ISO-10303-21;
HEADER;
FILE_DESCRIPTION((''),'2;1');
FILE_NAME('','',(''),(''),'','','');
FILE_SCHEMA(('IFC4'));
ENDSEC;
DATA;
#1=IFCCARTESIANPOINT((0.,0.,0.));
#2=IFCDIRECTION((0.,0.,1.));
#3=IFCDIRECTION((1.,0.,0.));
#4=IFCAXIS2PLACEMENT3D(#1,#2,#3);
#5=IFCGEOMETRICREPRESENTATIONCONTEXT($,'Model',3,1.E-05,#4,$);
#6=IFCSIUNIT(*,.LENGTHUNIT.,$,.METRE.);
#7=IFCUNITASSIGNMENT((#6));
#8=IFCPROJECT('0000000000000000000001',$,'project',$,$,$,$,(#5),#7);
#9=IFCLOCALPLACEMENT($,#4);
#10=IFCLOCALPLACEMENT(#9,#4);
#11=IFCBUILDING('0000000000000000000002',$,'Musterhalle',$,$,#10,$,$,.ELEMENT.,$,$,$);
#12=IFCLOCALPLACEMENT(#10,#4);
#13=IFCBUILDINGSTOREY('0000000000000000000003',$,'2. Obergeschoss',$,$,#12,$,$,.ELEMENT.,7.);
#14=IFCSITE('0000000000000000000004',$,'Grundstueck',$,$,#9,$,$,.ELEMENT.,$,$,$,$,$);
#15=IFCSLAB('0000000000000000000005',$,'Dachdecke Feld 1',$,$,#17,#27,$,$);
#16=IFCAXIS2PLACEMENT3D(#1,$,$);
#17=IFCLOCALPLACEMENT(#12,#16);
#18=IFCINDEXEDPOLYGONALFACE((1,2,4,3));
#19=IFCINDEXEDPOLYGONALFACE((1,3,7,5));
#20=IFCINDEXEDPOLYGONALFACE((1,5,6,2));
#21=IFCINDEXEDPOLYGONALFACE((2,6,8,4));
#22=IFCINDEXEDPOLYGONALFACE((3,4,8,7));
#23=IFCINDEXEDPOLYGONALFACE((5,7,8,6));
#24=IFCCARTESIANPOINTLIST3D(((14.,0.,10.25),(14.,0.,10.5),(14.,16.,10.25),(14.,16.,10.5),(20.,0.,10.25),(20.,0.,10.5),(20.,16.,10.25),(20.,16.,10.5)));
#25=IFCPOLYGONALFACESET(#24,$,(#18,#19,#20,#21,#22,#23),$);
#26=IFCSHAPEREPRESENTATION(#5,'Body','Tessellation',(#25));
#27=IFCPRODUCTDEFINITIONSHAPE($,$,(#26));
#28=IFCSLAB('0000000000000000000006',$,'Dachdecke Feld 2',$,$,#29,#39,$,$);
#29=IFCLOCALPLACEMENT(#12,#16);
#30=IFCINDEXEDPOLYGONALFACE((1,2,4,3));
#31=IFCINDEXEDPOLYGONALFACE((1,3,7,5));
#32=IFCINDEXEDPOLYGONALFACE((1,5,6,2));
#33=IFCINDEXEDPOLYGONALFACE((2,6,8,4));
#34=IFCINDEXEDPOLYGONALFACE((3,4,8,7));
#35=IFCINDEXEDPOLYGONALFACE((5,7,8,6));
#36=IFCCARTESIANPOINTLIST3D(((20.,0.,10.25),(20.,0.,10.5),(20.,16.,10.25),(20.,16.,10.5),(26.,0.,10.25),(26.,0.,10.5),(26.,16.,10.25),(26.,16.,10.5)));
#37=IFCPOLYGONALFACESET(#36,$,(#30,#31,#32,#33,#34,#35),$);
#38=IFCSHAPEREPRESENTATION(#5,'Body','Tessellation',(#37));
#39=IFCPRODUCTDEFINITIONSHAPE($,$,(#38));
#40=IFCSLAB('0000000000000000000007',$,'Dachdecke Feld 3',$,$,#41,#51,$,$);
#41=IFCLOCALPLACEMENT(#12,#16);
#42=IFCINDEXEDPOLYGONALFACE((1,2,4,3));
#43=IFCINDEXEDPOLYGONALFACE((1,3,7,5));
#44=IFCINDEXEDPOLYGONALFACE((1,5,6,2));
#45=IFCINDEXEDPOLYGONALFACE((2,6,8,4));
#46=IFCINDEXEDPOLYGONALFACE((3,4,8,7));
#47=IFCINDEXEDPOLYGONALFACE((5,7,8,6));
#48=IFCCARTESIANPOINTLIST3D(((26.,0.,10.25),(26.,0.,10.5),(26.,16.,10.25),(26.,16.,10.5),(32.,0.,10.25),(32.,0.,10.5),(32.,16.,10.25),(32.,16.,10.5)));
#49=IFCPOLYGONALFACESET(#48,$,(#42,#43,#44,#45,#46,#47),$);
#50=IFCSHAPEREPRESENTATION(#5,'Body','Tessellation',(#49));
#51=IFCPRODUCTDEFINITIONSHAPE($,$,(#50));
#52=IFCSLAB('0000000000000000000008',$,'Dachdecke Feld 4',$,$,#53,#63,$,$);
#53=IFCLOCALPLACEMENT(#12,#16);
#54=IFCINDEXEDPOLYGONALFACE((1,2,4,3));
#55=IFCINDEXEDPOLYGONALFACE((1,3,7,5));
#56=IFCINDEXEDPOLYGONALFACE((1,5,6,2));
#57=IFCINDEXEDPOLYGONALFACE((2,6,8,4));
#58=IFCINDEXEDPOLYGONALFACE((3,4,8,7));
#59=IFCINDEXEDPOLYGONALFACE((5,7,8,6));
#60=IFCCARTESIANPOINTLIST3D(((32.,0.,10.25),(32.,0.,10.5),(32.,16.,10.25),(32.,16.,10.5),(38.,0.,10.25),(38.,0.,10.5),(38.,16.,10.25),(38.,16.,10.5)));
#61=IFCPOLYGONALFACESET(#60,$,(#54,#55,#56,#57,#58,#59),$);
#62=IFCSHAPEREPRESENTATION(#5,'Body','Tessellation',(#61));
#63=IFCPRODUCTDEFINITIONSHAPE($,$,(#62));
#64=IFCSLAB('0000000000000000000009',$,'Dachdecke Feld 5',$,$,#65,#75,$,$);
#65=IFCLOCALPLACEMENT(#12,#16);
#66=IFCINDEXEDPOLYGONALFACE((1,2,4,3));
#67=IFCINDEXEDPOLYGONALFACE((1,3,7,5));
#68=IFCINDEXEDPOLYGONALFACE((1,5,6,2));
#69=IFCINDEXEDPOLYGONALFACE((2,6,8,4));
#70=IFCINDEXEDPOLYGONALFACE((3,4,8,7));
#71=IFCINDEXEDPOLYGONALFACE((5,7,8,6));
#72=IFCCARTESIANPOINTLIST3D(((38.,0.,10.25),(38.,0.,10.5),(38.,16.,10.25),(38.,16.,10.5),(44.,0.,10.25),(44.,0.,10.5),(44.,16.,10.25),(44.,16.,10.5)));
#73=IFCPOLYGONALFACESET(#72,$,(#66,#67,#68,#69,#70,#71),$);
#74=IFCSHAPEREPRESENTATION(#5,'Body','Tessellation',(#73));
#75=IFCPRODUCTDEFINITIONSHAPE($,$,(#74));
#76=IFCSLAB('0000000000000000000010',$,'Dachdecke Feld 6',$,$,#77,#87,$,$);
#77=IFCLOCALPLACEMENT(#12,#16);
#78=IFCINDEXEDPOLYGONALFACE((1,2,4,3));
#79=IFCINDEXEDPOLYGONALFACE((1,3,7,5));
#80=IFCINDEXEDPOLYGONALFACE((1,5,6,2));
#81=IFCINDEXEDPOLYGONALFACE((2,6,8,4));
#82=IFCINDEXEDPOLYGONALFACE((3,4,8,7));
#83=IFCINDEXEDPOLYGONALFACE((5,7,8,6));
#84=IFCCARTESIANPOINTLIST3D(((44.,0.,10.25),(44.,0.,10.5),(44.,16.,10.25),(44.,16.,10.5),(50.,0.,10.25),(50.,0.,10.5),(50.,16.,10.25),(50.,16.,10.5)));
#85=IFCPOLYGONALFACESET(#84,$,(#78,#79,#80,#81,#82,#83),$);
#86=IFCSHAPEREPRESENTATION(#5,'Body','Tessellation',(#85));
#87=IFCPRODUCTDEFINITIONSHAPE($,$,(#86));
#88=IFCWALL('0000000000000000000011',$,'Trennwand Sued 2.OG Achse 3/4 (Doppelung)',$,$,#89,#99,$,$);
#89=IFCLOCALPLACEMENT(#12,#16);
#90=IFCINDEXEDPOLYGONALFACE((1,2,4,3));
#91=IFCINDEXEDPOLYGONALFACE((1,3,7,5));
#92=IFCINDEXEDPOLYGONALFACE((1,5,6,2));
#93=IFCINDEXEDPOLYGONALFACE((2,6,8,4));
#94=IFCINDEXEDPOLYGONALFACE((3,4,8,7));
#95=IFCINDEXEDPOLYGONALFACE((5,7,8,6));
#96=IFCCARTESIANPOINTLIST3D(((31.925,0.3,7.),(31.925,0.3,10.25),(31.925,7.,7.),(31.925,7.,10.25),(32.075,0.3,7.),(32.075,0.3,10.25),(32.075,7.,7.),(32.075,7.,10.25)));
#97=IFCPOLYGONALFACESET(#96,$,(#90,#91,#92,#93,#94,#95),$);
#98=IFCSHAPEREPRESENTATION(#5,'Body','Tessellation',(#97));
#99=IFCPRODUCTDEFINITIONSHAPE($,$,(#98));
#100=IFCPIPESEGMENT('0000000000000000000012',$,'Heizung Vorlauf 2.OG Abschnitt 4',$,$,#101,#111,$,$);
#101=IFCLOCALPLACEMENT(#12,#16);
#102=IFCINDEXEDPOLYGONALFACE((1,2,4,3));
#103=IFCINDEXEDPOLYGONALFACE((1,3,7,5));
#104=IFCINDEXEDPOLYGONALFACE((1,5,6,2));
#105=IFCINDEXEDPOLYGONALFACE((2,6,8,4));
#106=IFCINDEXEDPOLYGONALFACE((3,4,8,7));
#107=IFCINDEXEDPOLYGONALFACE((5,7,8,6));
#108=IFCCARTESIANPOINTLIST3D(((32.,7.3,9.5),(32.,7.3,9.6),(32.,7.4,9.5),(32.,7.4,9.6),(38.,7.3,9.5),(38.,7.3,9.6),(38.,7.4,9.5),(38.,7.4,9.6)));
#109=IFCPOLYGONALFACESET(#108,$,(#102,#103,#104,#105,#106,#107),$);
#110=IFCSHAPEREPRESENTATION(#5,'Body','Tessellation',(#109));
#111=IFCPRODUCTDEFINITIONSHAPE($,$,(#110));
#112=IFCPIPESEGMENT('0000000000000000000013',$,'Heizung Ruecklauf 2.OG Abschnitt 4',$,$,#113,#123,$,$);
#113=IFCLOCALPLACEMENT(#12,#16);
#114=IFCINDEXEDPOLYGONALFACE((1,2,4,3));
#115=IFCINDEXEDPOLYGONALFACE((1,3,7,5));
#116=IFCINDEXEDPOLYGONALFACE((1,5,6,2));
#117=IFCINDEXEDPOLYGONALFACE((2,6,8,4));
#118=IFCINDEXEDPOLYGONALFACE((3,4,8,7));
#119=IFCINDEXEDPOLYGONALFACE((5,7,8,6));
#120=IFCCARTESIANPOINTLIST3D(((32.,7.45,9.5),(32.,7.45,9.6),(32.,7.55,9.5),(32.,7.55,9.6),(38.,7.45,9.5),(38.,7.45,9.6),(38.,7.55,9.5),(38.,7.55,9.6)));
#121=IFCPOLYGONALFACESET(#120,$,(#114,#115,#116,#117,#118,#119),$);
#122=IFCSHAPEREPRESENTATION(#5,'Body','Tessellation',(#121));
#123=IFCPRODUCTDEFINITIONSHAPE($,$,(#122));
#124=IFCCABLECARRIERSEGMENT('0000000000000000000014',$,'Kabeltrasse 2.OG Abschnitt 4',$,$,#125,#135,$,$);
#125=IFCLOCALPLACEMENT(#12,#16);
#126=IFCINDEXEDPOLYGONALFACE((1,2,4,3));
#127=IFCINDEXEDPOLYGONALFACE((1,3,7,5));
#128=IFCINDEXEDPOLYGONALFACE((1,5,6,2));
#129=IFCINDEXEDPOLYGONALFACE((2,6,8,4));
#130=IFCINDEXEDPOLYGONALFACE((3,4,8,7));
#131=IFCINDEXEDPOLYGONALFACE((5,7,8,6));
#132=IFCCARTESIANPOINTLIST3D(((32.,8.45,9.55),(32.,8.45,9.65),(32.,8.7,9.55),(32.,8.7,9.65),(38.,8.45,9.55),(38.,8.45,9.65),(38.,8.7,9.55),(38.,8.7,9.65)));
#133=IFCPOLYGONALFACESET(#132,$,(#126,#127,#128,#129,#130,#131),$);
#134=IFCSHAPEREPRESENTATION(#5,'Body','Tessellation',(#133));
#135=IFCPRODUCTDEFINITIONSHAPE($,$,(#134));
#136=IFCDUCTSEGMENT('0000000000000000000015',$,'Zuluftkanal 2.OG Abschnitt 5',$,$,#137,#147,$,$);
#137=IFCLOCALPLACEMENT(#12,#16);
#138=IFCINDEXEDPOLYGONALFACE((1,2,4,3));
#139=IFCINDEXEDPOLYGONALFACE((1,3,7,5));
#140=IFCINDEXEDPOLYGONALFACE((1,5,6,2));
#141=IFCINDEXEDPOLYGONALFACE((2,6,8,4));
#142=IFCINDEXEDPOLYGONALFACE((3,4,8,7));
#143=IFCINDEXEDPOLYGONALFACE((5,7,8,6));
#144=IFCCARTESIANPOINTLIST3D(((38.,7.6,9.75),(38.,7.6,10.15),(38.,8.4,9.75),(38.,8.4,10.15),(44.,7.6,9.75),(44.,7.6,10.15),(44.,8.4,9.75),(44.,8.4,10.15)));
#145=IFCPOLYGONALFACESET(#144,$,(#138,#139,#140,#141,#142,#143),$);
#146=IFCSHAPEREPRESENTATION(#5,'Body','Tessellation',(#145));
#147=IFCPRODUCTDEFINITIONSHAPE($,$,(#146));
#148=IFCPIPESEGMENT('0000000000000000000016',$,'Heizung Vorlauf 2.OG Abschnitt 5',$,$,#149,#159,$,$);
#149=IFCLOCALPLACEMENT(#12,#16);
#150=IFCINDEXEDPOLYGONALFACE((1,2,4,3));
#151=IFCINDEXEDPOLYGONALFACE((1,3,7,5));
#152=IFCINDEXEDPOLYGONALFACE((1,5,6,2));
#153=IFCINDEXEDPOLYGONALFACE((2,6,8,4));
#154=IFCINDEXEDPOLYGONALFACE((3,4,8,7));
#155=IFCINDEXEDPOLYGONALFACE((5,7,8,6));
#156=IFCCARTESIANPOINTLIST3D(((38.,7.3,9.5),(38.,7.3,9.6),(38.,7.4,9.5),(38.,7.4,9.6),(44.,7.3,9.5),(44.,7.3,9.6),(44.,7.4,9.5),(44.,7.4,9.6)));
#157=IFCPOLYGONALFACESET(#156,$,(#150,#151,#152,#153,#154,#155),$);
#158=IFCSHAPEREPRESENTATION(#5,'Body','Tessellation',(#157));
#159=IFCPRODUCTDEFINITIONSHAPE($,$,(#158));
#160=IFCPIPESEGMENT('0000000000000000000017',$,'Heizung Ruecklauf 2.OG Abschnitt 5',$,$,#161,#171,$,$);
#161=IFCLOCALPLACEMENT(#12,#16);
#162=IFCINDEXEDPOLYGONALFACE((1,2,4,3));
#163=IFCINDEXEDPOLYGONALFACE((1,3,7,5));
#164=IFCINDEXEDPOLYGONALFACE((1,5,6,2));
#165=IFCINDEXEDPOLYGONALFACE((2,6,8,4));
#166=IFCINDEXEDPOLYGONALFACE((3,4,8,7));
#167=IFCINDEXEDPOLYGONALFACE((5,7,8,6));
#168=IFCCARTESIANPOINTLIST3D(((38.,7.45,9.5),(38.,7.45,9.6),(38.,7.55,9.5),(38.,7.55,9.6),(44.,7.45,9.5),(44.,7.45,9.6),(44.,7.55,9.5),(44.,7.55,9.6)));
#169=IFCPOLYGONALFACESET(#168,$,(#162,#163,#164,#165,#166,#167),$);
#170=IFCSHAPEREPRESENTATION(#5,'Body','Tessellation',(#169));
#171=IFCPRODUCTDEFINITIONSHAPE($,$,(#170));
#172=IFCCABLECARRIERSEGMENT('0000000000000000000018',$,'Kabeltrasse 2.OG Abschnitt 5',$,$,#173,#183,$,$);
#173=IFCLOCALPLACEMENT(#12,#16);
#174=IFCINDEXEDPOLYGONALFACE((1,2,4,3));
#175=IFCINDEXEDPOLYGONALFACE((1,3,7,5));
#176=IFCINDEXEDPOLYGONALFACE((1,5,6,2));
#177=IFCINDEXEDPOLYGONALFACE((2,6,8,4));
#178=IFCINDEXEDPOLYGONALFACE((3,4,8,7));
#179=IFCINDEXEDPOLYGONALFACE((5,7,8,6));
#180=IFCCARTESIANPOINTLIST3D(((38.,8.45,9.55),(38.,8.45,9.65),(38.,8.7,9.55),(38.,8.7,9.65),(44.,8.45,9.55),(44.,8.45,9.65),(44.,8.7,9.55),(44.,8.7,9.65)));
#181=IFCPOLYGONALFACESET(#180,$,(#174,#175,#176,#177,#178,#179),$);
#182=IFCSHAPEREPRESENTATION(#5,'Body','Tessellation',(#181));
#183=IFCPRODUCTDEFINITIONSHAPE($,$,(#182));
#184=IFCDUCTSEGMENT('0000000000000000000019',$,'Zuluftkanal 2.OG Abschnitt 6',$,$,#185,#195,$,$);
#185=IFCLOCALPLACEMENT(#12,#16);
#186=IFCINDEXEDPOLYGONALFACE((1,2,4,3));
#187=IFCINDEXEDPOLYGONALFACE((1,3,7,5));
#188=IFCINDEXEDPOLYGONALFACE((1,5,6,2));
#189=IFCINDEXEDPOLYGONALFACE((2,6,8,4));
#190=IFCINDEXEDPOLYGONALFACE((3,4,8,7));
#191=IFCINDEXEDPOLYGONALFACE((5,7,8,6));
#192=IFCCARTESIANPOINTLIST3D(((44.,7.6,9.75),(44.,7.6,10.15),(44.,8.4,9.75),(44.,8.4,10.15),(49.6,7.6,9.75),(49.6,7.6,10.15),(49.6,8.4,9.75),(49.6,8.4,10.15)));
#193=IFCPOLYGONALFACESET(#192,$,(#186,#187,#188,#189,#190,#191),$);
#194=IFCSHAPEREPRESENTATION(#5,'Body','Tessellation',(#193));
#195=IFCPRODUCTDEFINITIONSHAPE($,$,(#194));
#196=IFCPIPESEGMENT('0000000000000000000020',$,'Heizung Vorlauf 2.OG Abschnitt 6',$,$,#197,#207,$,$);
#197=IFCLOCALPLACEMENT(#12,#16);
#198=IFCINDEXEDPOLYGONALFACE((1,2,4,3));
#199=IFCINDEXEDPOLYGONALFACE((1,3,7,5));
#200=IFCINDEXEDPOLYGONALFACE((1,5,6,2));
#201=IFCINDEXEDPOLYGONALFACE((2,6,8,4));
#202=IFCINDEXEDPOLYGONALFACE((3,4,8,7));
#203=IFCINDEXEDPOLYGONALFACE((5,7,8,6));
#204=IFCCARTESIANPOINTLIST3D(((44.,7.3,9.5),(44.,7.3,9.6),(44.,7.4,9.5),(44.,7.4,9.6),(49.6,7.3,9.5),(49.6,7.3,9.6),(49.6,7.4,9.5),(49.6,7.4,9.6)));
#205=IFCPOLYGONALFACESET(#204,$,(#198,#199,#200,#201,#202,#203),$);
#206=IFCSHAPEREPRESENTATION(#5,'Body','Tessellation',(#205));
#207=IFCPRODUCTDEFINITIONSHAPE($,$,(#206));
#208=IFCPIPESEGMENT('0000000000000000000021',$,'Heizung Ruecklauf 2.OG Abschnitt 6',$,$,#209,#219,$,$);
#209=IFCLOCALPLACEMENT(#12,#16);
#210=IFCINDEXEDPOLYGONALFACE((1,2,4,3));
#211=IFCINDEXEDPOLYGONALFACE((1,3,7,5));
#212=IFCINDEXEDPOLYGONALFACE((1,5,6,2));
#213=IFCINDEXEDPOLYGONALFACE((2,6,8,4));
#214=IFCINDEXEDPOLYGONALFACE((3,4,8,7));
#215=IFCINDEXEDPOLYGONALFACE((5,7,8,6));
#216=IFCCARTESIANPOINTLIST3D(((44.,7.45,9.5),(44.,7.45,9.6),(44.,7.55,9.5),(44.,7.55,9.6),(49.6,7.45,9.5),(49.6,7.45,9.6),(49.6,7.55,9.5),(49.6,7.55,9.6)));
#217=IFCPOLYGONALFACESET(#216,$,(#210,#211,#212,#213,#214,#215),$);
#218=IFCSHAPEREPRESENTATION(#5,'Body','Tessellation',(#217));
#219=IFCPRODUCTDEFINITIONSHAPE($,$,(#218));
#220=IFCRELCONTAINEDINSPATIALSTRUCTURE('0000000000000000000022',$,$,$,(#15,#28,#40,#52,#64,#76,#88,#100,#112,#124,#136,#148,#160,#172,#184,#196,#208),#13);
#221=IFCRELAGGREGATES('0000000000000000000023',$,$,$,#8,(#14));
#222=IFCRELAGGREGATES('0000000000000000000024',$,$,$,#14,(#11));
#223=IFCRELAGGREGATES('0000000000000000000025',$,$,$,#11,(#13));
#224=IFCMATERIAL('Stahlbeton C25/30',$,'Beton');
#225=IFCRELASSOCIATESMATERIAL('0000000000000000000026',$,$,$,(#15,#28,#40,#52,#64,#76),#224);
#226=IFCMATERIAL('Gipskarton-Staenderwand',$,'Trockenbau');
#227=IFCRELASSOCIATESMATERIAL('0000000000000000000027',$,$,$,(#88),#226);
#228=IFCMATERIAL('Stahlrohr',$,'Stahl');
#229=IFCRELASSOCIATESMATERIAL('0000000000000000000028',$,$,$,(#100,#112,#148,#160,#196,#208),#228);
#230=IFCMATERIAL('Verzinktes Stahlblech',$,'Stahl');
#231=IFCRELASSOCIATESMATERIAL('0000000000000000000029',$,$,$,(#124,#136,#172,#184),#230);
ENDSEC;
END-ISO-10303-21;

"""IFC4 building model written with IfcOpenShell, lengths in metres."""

from ifc_helpers import new_model, si_unit, frame, origin_with_axes, origin_2d, place, context, project, spatial, rectangle, extrude, material, element, save


model = new_model("IFC4")

# Units and contexts
model_context = context("Model", 3, precision=1e-05, world=origin_with_axes())
ifc_project = project(units=[si_unit("LENGTHUNIT", "METRE")], contexts=[model_context])

# Site, building, storey
site_placement = place(None, origin_with_axes())
site = spatial("IfcSite", under=ifc_project, at=site_placement, Name="Grundstueck", CompositionType="ELEMENT")
building_placement = place(site_placement, origin_with_axes())
building = spatial("IfcBuilding", under=site, at=building_placement, Name="Musterhalle", CompositionType="ELEMENT")
storey_placement = place(building_placement, origin_with_axes())
storey = spatial("IfcBuildingStorey", under=building, at=storey_placement, Name="2. Obergeschoss", CompositionType="ELEMENT", Elevation=7.0)

# Slabs
ifc_material_1 = material(Name="Stahlbeton C25/30", Category="Beton")
placement = place(storey_placement, origin_with_axes())
element("IfcSlab", 1, at=placement, inside=storey, material=ifc_material_1, Name="Dachdecke Feld 1", context=model_context, shape_type="SweptSolid", body=[
    extrude(rectangle(XDim=6.0, YDim=16.0, at=origin_2d()), frame((17.0, 8.0, 10.25), z_axis=(0.0, 0.0, 1.0), x_axis=(1.0, 0.0, 0.0)), (0.0, 0.0, 1.0), 0.25),
])
element("IfcSlab", 2, at=placement, inside=storey, material=ifc_material_1, Name="Dachdecke Feld 2", context=model_context, shape_type="SweptSolid", body=[
    extrude(rectangle(XDim=6.0, YDim=16.0, at=origin_2d()), frame((23.0, 8.0, 10.25), z_axis=(0.0, 0.0, 1.0), x_axis=(1.0, 0.0, 0.0)), (0.0, 0.0, 1.0), 0.25),
])
element("IfcSlab", 3, at=placement, inside=storey, material=ifc_material_1, Name="Dachdecke Feld 3", context=model_context, shape_type="SweptSolid", body=[
    extrude(rectangle(XDim=6.0, YDim=16.0, at=origin_2d()), frame((29.0, 8.0, 10.25), z_axis=(0.0, 0.0, 1.0), x_axis=(1.0, 0.0, 0.0)), (0.0, 0.0, 1.0), 0.25),
])
element("IfcSlab", 4, at=placement, inside=storey, material=ifc_material_1, Name="Dachdecke Feld 4", context=model_context, shape_type="SweptSolid", body=[
    extrude(rectangle(XDim=6.0, YDim=16.0, at=origin_2d()), frame((35.0, 8.0, 10.25), z_axis=(0.0, 0.0, 1.0), x_axis=(1.0, 0.0, 0.0)), (0.0, 0.0, 1.0), 0.25),
])
element("IfcSlab", 5, at=placement, inside=storey, material=ifc_material_1, Name="Dachdecke Feld 5", context=model_context, shape_type="SweptSolid", body=[
    extrude(rectangle(XDim=6.0, YDim=16.0, at=origin_2d()), frame((41.0, 8.0, 10.25), z_axis=(0.0, 0.0, 1.0), x_axis=(1.0, 0.0, 0.0)), (0.0, 0.0, 1.0), 0.25),
])
element("IfcSlab", 6, at=placement, inside=storey, material=ifc_material_1, Name="Dachdecke Feld 6", context=model_context, shape_type="SweptSolid", body=[
    extrude(rectangle(XDim=6.0, YDim=16.0, at=origin_2d()), frame((47.0, 8.0, 10.25), z_axis=(0.0, 0.0, 1.0), x_axis=(1.0, 0.0, 0.0)), (0.0, 0.0, 1.0), 0.25),
])

# Wall
ifc_material_2 = material(Name="Gipskarton-Staenderwand", Category="Trockenbau")
element("IfcWall", 7, at=placement, inside=storey, material=ifc_material_2, Name="Trennwand Sued 2.OG Achse 3/4 (Doppelung)", context=model_context, shape_type="SweptSolid", body=[
    extrude(rectangle(XDim=0.15, YDim=6.7, at=origin_2d()), frame((32.0, 3.65, 7.0), z_axis=(0.0, 0.0, 1.0), x_axis=(1.0, 0.0, 0.0)), (0.0, 0.0, 1.0), 3.25),
])

# Pipe segments
ifc_material_3 = material(Name="Stahlrohr", Category="Stahl")
element("IfcPipeSegment", 8, at=placement, inside=storey, material=ifc_material_3, Name="Heizung Vorlauf 2.OG Abschnitt 4", context=model_context, shape_type="SweptSolid", body=[
    extrude(rectangle(XDim=6.0, YDim=0.1, at=origin_2d()), frame((35.0, 7.35, 9.5), z_axis=(0.0, 0.0, 1.0), x_axis=(1.0, 0.0, 0.0)), (0.0, 0.0, 1.0), 0.1),
])
element("IfcPipeSegment", 9, at=placement, inside=storey, material=ifc_material_3, Name="Heizung Ruecklauf 2.OG Abschnitt 4", context=model_context, shape_type="SweptSolid", body=[
    extrude(rectangle(XDim=6.0, YDim=0.1, at=origin_2d()), frame((35.0, 7.5, 9.5), z_axis=(0.0, 0.0, 1.0), x_axis=(1.0, 0.0, 0.0)), (0.0, 0.0, 1.0), 0.1),
])

# Cable carrier segment
ifc_material_4 = material(Name="Verzinktes Stahlblech", Category="Stahl")
element("IfcCableCarrierSegment", 10, at=placement, inside=storey, material=ifc_material_4, Name="Kabeltrasse 2.OG Abschnitt 4", context=model_context, shape_type="SweptSolid", body=[
    extrude(rectangle(XDim=6.0, YDim=0.25, at=origin_2d()), frame((35.0, 8.575, 9.55), z_axis=(0.0, 0.0, 1.0), x_axis=(1.0, 0.0, 0.0)), (0.0, 0.0, 1.0), 0.1),
])

# Duct segment
element("IfcDuctSegment", 11, at=placement, inside=storey, material=ifc_material_4, Name="Zuluftkanal 2.OG Abschnitt 5", context=model_context, shape_type="SweptSolid", body=[
    extrude(rectangle(XDim=6.0, YDim=0.8, at=origin_2d()), frame((41.0, 8.0, 9.75), z_axis=(0.0, 0.0, 1.0), x_axis=(1.0, 0.0, 0.0)), (0.0, 0.0, 1.0), 0.4),
])

# Pipe segments
element("IfcPipeSegment", 12, at=placement, inside=storey, material=ifc_material_3, Name="Heizung Vorlauf 2.OG Abschnitt 5", context=model_context, shape_type="SweptSolid", body=[
    extrude(rectangle(XDim=6.0, YDim=0.1, at=origin_2d()), frame((41.0, 7.35, 9.5), z_axis=(0.0, 0.0, 1.0), x_axis=(1.0, 0.0, 0.0)), (0.0, 0.0, 1.0), 0.1),
])
element("IfcPipeSegment", 13, at=placement, inside=storey, material=ifc_material_3, Name="Heizung Ruecklauf 2.OG Abschnitt 5", context=model_context, shape_type="SweptSolid", body=[
    extrude(rectangle(XDim=6.0, YDim=0.1, at=origin_2d()), frame((41.0, 7.5, 9.5), z_axis=(0.0, 0.0, 1.0), x_axis=(1.0, 0.0, 0.0)), (0.0, 0.0, 1.0), 0.1),
])

# Cable carrier segment
element("IfcCableCarrierSegment", 14, at=placement, inside=storey, material=ifc_material_4, Name="Kabeltrasse 2.OG Abschnitt 5", context=model_context, shape_type="SweptSolid", body=[
    extrude(rectangle(XDim=6.0, YDim=0.25, at=origin_2d()), frame((41.0, 8.575, 9.55), z_axis=(0.0, 0.0, 1.0), x_axis=(1.0, 0.0, 0.0)), (0.0, 0.0, 1.0), 0.1),
])

# Duct segment
element("IfcDuctSegment", 15, at=placement, inside=storey, material=ifc_material_4, Name="Zuluftkanal 2.OG Abschnitt 6", context=model_context, shape_type="SweptSolid", body=[
    extrude(rectangle(XDim=5.6, YDim=0.8, at=origin_2d()), frame((46.8, 8.0, 9.75), z_axis=(0.0, 0.0, 1.0), x_axis=(1.0, 0.0, 0.0)), (0.0, 0.0, 1.0), 0.4),
])

# Pipe segments
element("IfcPipeSegment", 16, at=placement, inside=storey, material=ifc_material_3, Name="Heizung Vorlauf 2.OG Abschnitt 6", context=model_context, shape_type="SweptSolid", body=[
    extrude(rectangle(XDim=5.6, YDim=0.1, at=origin_2d()), frame((46.8, 7.35, 9.5), z_axis=(0.0, 0.0, 1.0), x_axis=(1.0, 0.0, 0.0)), (0.0, 0.0, 1.0), 0.1),
])
element("IfcPipeSegment", 17, at=placement, inside=storey, material=ifc_material_3, Name="Heizung Ruecklauf 2.OG Abschnitt 6", context=model_context, shape_type="SweptSolid", body=[
    extrude(rectangle(XDim=5.6, YDim=0.1, at=origin_2d()), frame((46.8, 7.5, 9.5), z_axis=(0.0, 0.0, 1.0), x_axis=(1.0, 0.0, 0.0)), (0.0, 0.0, 1.0), 0.1),
])

save(model, "model.ifc")
